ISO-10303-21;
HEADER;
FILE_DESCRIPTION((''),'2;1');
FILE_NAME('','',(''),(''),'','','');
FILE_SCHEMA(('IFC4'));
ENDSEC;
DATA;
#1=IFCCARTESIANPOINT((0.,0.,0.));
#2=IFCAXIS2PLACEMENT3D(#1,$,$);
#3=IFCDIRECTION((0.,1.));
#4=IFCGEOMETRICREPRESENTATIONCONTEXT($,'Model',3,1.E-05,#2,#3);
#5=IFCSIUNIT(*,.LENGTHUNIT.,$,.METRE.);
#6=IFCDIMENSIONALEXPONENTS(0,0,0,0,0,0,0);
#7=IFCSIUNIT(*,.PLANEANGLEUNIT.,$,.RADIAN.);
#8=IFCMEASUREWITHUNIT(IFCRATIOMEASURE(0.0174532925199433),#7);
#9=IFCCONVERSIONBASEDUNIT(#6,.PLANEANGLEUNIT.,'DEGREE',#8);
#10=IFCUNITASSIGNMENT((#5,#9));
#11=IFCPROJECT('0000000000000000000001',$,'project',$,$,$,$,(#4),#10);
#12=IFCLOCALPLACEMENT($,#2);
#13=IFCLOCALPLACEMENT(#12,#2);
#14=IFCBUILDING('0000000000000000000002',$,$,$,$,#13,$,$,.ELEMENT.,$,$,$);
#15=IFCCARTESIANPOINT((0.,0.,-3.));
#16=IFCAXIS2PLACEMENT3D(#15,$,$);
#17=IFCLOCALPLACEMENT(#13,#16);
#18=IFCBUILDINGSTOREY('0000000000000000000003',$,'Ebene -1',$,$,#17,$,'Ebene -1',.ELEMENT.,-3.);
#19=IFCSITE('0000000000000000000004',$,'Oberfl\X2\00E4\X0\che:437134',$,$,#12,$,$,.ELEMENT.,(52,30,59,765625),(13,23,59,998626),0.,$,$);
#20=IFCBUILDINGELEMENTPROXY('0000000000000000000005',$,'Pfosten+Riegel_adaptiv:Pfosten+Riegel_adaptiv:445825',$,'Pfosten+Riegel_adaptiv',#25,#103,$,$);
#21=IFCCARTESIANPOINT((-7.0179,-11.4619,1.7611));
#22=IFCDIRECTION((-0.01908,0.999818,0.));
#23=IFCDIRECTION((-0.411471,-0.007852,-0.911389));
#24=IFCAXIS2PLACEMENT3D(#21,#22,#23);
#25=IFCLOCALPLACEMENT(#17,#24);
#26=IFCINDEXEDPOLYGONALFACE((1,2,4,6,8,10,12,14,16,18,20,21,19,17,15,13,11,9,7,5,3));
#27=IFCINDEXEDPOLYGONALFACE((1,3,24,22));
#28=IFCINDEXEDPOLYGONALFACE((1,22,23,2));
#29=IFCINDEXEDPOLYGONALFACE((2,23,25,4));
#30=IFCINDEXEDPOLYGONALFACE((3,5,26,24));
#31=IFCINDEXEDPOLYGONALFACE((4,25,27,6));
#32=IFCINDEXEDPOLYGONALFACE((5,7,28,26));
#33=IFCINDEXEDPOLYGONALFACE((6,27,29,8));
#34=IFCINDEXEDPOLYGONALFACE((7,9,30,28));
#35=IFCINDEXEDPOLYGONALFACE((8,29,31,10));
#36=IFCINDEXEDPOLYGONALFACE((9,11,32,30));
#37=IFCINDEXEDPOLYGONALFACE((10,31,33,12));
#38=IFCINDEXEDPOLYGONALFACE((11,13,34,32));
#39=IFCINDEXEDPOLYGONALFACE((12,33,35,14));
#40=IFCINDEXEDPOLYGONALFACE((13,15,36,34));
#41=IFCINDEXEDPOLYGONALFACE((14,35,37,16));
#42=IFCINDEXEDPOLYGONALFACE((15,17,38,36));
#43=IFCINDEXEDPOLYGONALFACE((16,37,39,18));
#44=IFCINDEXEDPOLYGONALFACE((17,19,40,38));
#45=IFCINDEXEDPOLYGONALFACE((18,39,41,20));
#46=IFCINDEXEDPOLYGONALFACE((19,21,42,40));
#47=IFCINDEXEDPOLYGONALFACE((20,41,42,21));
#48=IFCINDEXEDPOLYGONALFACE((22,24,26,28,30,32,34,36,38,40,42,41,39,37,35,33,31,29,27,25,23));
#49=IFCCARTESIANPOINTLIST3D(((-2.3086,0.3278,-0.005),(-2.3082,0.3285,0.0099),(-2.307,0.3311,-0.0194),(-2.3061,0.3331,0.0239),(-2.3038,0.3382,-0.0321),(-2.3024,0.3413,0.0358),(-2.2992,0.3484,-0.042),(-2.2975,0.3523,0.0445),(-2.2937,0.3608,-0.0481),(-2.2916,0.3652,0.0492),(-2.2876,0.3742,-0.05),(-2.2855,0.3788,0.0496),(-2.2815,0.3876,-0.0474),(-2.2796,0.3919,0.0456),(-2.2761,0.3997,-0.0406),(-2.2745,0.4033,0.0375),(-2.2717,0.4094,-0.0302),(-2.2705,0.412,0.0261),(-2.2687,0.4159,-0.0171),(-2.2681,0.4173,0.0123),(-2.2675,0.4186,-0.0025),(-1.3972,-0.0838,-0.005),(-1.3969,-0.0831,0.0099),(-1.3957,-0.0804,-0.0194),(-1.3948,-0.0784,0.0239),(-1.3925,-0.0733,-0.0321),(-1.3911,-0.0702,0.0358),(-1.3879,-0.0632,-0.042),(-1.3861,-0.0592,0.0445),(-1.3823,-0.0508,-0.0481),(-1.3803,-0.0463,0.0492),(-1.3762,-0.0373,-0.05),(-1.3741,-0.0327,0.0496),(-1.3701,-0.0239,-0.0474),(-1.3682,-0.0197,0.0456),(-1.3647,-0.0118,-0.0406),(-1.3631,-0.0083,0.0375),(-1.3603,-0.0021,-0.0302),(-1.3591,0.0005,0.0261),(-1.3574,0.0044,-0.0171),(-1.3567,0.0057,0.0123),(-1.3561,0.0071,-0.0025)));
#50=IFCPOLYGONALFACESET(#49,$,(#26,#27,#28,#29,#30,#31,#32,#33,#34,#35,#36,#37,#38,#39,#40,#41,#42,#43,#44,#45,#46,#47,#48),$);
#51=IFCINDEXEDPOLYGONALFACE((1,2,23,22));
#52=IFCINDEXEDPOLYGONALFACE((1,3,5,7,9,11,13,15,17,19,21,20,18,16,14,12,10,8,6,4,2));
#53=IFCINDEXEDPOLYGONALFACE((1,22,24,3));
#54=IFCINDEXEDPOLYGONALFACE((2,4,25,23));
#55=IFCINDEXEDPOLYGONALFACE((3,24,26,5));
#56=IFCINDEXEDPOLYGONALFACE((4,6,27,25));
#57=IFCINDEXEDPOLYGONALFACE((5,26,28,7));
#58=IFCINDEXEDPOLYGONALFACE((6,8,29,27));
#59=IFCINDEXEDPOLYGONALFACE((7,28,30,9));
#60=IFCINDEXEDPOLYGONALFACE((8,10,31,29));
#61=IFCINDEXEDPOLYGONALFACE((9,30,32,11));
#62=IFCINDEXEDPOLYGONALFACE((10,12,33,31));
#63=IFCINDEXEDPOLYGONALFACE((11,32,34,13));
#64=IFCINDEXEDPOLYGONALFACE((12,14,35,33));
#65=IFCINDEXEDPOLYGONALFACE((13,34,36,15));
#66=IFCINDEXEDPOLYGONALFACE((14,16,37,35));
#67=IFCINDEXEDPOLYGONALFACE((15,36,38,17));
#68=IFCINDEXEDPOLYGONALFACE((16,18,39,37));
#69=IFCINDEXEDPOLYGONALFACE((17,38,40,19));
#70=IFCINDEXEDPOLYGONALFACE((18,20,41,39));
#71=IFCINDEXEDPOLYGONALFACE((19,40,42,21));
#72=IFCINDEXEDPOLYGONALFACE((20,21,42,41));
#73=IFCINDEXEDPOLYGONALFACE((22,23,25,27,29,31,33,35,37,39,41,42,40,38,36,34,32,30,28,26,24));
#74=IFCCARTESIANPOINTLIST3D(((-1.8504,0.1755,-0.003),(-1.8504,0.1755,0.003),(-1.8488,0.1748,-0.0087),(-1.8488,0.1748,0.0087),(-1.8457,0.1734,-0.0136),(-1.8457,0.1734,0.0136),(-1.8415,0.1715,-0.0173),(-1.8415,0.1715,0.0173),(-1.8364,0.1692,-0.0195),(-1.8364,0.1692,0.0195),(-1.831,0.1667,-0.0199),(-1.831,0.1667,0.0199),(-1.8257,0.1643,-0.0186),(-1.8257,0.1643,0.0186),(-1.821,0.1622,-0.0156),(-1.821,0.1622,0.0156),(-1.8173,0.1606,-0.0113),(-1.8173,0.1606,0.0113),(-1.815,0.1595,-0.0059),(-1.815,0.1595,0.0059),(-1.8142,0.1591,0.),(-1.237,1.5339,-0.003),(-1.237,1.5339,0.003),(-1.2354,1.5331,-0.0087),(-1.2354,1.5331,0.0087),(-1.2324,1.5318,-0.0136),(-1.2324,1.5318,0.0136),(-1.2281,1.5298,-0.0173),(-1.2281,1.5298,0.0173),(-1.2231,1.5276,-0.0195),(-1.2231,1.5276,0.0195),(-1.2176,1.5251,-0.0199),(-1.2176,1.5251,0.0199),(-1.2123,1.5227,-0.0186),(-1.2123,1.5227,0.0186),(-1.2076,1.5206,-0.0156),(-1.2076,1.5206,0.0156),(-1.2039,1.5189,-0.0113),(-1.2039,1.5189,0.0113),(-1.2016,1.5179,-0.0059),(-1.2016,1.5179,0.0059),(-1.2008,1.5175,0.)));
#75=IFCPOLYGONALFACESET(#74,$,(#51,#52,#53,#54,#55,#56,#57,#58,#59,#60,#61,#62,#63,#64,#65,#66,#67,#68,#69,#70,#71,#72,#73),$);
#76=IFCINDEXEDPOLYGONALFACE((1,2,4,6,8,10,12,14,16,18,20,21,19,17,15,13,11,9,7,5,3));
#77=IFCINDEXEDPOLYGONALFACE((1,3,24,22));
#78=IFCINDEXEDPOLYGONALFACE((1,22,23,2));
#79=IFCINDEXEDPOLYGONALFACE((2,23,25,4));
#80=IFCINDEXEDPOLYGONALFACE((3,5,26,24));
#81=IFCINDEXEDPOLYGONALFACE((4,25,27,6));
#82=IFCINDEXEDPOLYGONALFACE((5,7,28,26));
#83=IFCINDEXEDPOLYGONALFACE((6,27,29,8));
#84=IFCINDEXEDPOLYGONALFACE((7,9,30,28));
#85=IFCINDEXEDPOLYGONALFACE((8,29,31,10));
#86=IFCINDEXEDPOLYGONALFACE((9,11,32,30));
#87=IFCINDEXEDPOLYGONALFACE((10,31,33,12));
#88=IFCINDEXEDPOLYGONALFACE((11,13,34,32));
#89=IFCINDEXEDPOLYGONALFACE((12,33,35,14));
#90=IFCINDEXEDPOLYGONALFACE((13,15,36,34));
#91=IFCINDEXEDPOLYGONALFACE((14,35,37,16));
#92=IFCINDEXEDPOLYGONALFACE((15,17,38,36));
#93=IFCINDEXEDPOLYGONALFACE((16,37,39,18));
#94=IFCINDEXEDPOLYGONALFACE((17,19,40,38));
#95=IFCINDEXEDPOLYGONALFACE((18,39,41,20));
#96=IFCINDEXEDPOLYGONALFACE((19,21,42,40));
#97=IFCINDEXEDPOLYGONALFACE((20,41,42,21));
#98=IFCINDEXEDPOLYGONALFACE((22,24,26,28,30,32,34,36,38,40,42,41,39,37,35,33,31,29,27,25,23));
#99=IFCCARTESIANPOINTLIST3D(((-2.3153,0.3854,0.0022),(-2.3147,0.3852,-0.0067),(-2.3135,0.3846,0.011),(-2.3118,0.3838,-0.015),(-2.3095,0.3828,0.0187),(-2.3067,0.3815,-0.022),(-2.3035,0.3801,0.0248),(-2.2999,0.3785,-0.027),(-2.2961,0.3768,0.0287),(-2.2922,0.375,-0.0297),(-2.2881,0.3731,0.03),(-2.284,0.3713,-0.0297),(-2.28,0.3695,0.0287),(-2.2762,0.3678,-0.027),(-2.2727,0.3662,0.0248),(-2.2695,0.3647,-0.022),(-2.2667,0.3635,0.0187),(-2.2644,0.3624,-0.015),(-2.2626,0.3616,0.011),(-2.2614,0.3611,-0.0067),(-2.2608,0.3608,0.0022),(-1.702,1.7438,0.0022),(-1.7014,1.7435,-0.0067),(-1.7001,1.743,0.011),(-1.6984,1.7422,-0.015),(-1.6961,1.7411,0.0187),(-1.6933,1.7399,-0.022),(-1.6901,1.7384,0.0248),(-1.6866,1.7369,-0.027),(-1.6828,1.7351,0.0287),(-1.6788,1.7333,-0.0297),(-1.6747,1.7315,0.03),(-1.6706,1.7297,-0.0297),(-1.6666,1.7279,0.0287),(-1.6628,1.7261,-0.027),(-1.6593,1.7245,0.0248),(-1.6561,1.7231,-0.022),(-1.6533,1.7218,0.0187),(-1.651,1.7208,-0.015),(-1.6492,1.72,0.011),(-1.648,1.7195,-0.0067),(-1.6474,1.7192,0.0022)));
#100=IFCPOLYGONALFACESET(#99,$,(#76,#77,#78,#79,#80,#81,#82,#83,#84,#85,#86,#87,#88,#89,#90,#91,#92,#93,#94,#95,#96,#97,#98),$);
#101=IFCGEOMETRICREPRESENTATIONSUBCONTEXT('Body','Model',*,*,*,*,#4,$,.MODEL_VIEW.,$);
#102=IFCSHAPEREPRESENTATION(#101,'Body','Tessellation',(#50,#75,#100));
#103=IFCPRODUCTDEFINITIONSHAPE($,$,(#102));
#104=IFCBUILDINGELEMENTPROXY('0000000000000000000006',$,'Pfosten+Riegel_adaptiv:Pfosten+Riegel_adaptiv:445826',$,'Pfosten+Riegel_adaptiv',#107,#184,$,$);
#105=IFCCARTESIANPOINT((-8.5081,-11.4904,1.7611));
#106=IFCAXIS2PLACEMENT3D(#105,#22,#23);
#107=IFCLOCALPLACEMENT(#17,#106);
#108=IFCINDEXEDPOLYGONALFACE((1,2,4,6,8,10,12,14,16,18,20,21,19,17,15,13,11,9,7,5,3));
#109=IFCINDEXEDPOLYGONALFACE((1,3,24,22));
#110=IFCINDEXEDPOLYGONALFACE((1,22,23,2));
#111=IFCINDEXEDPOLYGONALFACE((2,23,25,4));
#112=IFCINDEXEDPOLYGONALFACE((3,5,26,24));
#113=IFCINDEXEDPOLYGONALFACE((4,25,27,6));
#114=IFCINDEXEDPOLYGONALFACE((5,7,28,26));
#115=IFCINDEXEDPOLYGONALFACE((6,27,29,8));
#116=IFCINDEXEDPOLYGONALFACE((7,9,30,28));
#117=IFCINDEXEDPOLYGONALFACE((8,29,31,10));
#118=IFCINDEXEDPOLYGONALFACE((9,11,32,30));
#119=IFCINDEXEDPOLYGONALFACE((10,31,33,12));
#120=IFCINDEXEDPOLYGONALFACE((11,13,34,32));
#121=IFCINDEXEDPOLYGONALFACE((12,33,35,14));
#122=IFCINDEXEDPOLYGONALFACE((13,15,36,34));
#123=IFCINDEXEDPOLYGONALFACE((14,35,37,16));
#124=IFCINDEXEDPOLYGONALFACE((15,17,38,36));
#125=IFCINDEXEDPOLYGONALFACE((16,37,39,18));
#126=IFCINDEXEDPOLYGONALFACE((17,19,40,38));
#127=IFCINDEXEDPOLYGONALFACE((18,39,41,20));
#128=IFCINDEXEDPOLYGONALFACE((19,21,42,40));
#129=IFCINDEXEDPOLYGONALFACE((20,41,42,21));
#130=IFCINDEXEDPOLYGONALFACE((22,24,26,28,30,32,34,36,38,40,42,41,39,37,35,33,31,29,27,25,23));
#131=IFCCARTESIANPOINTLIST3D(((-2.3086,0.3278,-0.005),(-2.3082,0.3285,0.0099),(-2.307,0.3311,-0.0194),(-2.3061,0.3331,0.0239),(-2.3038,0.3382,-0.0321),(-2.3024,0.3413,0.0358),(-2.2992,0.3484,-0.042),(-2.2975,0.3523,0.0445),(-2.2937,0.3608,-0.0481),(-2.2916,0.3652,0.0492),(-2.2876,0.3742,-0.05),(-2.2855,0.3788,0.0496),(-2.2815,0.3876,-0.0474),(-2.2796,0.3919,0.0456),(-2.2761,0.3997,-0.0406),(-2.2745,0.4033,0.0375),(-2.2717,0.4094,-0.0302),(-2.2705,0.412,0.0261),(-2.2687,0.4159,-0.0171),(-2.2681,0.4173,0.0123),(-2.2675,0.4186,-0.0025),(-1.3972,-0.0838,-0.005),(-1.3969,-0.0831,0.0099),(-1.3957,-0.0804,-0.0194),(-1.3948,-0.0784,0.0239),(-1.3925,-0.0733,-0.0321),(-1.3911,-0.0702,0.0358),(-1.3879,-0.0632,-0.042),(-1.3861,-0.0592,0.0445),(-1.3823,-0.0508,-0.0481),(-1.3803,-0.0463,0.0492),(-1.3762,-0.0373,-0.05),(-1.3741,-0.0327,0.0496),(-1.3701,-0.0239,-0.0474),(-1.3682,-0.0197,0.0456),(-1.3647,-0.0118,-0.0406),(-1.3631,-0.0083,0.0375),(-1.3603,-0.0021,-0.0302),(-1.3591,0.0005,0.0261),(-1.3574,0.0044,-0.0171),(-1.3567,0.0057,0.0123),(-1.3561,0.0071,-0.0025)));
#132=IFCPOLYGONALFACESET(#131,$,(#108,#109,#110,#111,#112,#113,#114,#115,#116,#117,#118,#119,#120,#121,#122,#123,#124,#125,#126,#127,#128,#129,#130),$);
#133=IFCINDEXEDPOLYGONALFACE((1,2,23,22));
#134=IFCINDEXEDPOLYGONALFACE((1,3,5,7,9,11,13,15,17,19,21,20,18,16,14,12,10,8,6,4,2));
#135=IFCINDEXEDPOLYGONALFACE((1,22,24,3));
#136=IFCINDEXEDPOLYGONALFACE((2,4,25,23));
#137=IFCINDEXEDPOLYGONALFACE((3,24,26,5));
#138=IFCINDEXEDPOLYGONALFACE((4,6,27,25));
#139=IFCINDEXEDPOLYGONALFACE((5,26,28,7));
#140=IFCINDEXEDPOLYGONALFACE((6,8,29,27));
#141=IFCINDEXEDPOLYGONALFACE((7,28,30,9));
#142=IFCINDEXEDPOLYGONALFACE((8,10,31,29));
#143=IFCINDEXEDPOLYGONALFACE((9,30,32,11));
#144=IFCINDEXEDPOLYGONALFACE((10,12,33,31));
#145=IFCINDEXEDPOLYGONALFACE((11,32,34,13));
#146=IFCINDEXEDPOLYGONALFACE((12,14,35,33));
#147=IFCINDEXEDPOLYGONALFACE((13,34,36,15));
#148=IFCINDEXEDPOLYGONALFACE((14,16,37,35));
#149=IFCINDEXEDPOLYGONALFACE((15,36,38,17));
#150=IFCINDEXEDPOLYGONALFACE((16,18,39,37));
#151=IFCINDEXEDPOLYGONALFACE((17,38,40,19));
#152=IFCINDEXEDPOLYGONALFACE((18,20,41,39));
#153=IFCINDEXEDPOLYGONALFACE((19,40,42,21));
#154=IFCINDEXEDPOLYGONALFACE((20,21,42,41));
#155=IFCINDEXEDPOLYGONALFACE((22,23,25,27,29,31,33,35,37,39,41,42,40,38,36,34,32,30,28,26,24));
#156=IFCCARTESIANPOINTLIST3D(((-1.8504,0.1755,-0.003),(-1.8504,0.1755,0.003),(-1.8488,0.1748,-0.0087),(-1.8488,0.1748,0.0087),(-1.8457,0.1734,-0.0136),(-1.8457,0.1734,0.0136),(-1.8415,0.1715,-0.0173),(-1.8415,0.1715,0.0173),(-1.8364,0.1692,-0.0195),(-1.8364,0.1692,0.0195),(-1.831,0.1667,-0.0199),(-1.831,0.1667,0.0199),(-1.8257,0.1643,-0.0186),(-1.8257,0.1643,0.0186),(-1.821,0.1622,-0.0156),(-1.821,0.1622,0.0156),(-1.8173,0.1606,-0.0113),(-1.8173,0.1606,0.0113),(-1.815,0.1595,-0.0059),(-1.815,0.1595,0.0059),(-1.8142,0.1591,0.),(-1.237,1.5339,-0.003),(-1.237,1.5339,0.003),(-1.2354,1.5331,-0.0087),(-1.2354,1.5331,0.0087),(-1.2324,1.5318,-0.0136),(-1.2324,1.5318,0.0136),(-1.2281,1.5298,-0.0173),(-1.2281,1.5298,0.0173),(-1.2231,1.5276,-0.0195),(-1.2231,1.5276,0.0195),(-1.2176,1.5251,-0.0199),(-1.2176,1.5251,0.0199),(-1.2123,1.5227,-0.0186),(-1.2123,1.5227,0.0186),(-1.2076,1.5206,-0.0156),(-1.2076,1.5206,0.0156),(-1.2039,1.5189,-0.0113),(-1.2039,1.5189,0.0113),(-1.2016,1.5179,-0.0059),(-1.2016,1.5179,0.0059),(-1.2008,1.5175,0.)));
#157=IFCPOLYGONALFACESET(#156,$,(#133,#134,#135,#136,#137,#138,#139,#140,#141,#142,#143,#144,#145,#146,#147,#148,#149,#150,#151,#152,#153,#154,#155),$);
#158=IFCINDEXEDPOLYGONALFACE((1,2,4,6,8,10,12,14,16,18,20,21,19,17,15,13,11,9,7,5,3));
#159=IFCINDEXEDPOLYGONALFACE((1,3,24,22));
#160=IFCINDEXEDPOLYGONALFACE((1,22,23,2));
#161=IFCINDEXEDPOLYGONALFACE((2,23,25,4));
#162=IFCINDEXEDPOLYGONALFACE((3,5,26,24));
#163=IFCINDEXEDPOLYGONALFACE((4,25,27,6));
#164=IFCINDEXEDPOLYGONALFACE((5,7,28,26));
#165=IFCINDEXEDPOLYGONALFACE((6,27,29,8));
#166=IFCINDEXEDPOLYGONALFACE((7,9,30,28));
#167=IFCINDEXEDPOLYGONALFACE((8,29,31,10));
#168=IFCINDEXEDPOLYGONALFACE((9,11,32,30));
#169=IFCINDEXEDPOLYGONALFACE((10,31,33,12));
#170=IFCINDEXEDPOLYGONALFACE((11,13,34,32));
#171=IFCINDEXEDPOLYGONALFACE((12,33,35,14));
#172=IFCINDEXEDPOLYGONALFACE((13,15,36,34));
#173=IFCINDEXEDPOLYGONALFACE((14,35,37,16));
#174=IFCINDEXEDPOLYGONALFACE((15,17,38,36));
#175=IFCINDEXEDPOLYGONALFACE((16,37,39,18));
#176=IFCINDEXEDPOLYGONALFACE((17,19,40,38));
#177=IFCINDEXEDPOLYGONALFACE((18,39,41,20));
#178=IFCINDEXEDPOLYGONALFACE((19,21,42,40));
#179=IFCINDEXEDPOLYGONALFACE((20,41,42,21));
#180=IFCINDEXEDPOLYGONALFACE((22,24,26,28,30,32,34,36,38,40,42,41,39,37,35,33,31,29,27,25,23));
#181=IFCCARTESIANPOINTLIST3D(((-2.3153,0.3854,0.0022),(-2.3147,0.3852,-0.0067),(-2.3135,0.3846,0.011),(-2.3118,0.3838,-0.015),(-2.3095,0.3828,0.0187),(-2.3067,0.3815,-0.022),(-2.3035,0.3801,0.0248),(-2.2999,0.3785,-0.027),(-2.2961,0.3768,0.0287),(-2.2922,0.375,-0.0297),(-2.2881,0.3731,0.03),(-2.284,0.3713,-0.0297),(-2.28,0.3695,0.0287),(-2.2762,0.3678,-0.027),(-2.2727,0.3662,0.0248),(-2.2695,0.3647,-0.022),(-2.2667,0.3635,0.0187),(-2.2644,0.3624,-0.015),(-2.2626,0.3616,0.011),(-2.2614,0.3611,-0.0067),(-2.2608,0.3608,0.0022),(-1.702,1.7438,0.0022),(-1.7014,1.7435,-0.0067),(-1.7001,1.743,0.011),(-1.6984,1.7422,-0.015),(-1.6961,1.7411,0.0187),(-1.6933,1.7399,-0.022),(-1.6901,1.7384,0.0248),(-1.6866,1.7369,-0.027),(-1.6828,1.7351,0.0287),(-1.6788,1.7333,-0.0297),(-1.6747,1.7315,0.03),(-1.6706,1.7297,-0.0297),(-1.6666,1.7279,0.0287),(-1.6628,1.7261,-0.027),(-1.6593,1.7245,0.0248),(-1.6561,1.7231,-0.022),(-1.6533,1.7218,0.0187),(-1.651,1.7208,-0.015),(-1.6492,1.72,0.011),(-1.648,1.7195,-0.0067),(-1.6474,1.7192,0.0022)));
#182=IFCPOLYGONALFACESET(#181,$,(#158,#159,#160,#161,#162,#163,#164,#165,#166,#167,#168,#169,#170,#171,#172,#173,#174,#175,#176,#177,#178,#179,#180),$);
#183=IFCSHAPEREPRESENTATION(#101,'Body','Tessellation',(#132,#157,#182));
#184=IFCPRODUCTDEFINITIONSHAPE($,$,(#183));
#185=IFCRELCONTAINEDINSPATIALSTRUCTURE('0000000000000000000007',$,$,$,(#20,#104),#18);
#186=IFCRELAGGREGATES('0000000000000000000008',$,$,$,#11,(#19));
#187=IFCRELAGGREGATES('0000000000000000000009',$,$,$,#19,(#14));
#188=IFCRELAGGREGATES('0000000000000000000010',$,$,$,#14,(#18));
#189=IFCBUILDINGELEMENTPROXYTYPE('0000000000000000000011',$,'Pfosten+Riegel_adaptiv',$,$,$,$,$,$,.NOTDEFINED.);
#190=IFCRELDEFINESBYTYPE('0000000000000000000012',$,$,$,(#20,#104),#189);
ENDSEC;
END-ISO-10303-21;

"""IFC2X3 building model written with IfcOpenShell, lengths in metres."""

from ifc_helpers import new_model, entity, si_unit, converted_unit, direction, frame, frame_2d, origin, place, context, subcontext, project, spatial, circle, extrude, source, transform, mapped, type_object, type_shapes, element, save


model = new_model("IFC2X3")

# Units and contexts
model_context = context("Model", 3, precision=1e-05, world=origin(), true_north=direction((0.0, 1.0)))
body_context = subcontext(model_context, "Body", "Model", "MODEL_VIEW")
ifc_project = project(units=[si_unit("LENGTHUNIT", "METRE"), converted_unit("PLANEANGLEUNIT", "DEGREE", entity("IfcRatioMeasure", 0.0174532925199433), si_unit("PLANEANGLEUNIT", "RADIAN"), dimensions=[0, 0, 0, 0, 0, 0, 0])], contexts=[model_context])

# Site, building, storey
site_placement = place(None, origin())
site = spatial("IfcSite", under=ifc_project, at=site_placement, Name="Oberfläche:437134", CompositionType="ELEMENT", RefLatitude=(52, 30, 59, 765625), RefLongitude=(13, 23, 59, 998626), RefElevation=0.0)
building_placement = place(site_placement, origin())
building = spatial("IfcBuilding", under=site, at=building_placement, CompositionType="ELEMENT")
storey_placement = place(building_placement, frame((0.0, 0.0, -3.0)))
storey = spatial("IfcBuildingStorey", under=building, at=storey_placement, Name="Ebene -1", LongName="Ebene -1", CompositionType="ELEMENT", Elevation=-3.0)

# Building element proxies
building_element_proxy_type_1 = type_object("IfcBuildingElementProxyType", Name="Pfosten+Riegel_adaptiv", PredefinedType="NOTDEFINED")
shared_shape_1 = source(origin(), body_context, "Body", "SweptSolid", [
    extrude(circle(Radius=0.05, at=frame_2d((0.0, 0.0), x_axis=(1.0, 0.0))), frame((-2.2881, 0.3731, 0.0), z_axis=(0.911389, -0.411546, 0.0), x_axis=(0.16937, 0.375078, 0.911389)), (0.0, 0.0, 1.0), 1.0),
    extrude(circle(Radius=0.02, at=frame_2d((0.0, 0.0), x_axis=(1.0, 0.0))), frame((-1.8324, 0.1674, 0.0), z_axis=(0.411546, 0.911389, 0.0), x_axis=(0.911389, -0.411546, 0.0)), (0.0, 0.0, 1.0), 1.4904),
    extrude(circle(Radius=0.03, at=frame_2d((0.0, 0.0), x_axis=(1.0, 0.0))), frame((-2.2881, 0.3731, 0.0), z_axis=(0.411546, 0.911389, 0.0), x_axis=(0.0, 0.0, 1.0)), (0.0, 0.0, 1.0), 1.4904),
])
type_shapes(building_element_proxy_type_1, [shared_shape_1])
for number, where, z_axis, x_axis, name in (
    (1, (-7.0179, -11.4619, 1.7611), (-0.01908, 0.999818, 0.0), (-0.411471, -0.007852, -0.911389), "Pfosten+Riegel_adaptiv:Pfosten+Riegel_adaptiv:445825"),
    (2, (-8.5081, -11.4904, 1.7611), (-0.01908, 0.999818, 0.0), (-0.411471, -0.007852, -0.911389), "Pfosten+Riegel_adaptiv:Pfosten+Riegel_adaptiv:445826"),
):
    element("IfcBuildingElementProxy", number, at=place(storey_placement, frame(where, z_axis=z_axis, x_axis=x_axis)), inside=storey, type_object=building_element_proxy_type_1, Name=name, ObjectType="Pfosten+Riegel_adaptiv", context=body_context, shape_type="MappedRepresentation", body=[
        mapped(shared_shape_1, transform((0.0, 0.0, 0.0), scale=1.0)),
    ])

save(model, "model.ifc")
